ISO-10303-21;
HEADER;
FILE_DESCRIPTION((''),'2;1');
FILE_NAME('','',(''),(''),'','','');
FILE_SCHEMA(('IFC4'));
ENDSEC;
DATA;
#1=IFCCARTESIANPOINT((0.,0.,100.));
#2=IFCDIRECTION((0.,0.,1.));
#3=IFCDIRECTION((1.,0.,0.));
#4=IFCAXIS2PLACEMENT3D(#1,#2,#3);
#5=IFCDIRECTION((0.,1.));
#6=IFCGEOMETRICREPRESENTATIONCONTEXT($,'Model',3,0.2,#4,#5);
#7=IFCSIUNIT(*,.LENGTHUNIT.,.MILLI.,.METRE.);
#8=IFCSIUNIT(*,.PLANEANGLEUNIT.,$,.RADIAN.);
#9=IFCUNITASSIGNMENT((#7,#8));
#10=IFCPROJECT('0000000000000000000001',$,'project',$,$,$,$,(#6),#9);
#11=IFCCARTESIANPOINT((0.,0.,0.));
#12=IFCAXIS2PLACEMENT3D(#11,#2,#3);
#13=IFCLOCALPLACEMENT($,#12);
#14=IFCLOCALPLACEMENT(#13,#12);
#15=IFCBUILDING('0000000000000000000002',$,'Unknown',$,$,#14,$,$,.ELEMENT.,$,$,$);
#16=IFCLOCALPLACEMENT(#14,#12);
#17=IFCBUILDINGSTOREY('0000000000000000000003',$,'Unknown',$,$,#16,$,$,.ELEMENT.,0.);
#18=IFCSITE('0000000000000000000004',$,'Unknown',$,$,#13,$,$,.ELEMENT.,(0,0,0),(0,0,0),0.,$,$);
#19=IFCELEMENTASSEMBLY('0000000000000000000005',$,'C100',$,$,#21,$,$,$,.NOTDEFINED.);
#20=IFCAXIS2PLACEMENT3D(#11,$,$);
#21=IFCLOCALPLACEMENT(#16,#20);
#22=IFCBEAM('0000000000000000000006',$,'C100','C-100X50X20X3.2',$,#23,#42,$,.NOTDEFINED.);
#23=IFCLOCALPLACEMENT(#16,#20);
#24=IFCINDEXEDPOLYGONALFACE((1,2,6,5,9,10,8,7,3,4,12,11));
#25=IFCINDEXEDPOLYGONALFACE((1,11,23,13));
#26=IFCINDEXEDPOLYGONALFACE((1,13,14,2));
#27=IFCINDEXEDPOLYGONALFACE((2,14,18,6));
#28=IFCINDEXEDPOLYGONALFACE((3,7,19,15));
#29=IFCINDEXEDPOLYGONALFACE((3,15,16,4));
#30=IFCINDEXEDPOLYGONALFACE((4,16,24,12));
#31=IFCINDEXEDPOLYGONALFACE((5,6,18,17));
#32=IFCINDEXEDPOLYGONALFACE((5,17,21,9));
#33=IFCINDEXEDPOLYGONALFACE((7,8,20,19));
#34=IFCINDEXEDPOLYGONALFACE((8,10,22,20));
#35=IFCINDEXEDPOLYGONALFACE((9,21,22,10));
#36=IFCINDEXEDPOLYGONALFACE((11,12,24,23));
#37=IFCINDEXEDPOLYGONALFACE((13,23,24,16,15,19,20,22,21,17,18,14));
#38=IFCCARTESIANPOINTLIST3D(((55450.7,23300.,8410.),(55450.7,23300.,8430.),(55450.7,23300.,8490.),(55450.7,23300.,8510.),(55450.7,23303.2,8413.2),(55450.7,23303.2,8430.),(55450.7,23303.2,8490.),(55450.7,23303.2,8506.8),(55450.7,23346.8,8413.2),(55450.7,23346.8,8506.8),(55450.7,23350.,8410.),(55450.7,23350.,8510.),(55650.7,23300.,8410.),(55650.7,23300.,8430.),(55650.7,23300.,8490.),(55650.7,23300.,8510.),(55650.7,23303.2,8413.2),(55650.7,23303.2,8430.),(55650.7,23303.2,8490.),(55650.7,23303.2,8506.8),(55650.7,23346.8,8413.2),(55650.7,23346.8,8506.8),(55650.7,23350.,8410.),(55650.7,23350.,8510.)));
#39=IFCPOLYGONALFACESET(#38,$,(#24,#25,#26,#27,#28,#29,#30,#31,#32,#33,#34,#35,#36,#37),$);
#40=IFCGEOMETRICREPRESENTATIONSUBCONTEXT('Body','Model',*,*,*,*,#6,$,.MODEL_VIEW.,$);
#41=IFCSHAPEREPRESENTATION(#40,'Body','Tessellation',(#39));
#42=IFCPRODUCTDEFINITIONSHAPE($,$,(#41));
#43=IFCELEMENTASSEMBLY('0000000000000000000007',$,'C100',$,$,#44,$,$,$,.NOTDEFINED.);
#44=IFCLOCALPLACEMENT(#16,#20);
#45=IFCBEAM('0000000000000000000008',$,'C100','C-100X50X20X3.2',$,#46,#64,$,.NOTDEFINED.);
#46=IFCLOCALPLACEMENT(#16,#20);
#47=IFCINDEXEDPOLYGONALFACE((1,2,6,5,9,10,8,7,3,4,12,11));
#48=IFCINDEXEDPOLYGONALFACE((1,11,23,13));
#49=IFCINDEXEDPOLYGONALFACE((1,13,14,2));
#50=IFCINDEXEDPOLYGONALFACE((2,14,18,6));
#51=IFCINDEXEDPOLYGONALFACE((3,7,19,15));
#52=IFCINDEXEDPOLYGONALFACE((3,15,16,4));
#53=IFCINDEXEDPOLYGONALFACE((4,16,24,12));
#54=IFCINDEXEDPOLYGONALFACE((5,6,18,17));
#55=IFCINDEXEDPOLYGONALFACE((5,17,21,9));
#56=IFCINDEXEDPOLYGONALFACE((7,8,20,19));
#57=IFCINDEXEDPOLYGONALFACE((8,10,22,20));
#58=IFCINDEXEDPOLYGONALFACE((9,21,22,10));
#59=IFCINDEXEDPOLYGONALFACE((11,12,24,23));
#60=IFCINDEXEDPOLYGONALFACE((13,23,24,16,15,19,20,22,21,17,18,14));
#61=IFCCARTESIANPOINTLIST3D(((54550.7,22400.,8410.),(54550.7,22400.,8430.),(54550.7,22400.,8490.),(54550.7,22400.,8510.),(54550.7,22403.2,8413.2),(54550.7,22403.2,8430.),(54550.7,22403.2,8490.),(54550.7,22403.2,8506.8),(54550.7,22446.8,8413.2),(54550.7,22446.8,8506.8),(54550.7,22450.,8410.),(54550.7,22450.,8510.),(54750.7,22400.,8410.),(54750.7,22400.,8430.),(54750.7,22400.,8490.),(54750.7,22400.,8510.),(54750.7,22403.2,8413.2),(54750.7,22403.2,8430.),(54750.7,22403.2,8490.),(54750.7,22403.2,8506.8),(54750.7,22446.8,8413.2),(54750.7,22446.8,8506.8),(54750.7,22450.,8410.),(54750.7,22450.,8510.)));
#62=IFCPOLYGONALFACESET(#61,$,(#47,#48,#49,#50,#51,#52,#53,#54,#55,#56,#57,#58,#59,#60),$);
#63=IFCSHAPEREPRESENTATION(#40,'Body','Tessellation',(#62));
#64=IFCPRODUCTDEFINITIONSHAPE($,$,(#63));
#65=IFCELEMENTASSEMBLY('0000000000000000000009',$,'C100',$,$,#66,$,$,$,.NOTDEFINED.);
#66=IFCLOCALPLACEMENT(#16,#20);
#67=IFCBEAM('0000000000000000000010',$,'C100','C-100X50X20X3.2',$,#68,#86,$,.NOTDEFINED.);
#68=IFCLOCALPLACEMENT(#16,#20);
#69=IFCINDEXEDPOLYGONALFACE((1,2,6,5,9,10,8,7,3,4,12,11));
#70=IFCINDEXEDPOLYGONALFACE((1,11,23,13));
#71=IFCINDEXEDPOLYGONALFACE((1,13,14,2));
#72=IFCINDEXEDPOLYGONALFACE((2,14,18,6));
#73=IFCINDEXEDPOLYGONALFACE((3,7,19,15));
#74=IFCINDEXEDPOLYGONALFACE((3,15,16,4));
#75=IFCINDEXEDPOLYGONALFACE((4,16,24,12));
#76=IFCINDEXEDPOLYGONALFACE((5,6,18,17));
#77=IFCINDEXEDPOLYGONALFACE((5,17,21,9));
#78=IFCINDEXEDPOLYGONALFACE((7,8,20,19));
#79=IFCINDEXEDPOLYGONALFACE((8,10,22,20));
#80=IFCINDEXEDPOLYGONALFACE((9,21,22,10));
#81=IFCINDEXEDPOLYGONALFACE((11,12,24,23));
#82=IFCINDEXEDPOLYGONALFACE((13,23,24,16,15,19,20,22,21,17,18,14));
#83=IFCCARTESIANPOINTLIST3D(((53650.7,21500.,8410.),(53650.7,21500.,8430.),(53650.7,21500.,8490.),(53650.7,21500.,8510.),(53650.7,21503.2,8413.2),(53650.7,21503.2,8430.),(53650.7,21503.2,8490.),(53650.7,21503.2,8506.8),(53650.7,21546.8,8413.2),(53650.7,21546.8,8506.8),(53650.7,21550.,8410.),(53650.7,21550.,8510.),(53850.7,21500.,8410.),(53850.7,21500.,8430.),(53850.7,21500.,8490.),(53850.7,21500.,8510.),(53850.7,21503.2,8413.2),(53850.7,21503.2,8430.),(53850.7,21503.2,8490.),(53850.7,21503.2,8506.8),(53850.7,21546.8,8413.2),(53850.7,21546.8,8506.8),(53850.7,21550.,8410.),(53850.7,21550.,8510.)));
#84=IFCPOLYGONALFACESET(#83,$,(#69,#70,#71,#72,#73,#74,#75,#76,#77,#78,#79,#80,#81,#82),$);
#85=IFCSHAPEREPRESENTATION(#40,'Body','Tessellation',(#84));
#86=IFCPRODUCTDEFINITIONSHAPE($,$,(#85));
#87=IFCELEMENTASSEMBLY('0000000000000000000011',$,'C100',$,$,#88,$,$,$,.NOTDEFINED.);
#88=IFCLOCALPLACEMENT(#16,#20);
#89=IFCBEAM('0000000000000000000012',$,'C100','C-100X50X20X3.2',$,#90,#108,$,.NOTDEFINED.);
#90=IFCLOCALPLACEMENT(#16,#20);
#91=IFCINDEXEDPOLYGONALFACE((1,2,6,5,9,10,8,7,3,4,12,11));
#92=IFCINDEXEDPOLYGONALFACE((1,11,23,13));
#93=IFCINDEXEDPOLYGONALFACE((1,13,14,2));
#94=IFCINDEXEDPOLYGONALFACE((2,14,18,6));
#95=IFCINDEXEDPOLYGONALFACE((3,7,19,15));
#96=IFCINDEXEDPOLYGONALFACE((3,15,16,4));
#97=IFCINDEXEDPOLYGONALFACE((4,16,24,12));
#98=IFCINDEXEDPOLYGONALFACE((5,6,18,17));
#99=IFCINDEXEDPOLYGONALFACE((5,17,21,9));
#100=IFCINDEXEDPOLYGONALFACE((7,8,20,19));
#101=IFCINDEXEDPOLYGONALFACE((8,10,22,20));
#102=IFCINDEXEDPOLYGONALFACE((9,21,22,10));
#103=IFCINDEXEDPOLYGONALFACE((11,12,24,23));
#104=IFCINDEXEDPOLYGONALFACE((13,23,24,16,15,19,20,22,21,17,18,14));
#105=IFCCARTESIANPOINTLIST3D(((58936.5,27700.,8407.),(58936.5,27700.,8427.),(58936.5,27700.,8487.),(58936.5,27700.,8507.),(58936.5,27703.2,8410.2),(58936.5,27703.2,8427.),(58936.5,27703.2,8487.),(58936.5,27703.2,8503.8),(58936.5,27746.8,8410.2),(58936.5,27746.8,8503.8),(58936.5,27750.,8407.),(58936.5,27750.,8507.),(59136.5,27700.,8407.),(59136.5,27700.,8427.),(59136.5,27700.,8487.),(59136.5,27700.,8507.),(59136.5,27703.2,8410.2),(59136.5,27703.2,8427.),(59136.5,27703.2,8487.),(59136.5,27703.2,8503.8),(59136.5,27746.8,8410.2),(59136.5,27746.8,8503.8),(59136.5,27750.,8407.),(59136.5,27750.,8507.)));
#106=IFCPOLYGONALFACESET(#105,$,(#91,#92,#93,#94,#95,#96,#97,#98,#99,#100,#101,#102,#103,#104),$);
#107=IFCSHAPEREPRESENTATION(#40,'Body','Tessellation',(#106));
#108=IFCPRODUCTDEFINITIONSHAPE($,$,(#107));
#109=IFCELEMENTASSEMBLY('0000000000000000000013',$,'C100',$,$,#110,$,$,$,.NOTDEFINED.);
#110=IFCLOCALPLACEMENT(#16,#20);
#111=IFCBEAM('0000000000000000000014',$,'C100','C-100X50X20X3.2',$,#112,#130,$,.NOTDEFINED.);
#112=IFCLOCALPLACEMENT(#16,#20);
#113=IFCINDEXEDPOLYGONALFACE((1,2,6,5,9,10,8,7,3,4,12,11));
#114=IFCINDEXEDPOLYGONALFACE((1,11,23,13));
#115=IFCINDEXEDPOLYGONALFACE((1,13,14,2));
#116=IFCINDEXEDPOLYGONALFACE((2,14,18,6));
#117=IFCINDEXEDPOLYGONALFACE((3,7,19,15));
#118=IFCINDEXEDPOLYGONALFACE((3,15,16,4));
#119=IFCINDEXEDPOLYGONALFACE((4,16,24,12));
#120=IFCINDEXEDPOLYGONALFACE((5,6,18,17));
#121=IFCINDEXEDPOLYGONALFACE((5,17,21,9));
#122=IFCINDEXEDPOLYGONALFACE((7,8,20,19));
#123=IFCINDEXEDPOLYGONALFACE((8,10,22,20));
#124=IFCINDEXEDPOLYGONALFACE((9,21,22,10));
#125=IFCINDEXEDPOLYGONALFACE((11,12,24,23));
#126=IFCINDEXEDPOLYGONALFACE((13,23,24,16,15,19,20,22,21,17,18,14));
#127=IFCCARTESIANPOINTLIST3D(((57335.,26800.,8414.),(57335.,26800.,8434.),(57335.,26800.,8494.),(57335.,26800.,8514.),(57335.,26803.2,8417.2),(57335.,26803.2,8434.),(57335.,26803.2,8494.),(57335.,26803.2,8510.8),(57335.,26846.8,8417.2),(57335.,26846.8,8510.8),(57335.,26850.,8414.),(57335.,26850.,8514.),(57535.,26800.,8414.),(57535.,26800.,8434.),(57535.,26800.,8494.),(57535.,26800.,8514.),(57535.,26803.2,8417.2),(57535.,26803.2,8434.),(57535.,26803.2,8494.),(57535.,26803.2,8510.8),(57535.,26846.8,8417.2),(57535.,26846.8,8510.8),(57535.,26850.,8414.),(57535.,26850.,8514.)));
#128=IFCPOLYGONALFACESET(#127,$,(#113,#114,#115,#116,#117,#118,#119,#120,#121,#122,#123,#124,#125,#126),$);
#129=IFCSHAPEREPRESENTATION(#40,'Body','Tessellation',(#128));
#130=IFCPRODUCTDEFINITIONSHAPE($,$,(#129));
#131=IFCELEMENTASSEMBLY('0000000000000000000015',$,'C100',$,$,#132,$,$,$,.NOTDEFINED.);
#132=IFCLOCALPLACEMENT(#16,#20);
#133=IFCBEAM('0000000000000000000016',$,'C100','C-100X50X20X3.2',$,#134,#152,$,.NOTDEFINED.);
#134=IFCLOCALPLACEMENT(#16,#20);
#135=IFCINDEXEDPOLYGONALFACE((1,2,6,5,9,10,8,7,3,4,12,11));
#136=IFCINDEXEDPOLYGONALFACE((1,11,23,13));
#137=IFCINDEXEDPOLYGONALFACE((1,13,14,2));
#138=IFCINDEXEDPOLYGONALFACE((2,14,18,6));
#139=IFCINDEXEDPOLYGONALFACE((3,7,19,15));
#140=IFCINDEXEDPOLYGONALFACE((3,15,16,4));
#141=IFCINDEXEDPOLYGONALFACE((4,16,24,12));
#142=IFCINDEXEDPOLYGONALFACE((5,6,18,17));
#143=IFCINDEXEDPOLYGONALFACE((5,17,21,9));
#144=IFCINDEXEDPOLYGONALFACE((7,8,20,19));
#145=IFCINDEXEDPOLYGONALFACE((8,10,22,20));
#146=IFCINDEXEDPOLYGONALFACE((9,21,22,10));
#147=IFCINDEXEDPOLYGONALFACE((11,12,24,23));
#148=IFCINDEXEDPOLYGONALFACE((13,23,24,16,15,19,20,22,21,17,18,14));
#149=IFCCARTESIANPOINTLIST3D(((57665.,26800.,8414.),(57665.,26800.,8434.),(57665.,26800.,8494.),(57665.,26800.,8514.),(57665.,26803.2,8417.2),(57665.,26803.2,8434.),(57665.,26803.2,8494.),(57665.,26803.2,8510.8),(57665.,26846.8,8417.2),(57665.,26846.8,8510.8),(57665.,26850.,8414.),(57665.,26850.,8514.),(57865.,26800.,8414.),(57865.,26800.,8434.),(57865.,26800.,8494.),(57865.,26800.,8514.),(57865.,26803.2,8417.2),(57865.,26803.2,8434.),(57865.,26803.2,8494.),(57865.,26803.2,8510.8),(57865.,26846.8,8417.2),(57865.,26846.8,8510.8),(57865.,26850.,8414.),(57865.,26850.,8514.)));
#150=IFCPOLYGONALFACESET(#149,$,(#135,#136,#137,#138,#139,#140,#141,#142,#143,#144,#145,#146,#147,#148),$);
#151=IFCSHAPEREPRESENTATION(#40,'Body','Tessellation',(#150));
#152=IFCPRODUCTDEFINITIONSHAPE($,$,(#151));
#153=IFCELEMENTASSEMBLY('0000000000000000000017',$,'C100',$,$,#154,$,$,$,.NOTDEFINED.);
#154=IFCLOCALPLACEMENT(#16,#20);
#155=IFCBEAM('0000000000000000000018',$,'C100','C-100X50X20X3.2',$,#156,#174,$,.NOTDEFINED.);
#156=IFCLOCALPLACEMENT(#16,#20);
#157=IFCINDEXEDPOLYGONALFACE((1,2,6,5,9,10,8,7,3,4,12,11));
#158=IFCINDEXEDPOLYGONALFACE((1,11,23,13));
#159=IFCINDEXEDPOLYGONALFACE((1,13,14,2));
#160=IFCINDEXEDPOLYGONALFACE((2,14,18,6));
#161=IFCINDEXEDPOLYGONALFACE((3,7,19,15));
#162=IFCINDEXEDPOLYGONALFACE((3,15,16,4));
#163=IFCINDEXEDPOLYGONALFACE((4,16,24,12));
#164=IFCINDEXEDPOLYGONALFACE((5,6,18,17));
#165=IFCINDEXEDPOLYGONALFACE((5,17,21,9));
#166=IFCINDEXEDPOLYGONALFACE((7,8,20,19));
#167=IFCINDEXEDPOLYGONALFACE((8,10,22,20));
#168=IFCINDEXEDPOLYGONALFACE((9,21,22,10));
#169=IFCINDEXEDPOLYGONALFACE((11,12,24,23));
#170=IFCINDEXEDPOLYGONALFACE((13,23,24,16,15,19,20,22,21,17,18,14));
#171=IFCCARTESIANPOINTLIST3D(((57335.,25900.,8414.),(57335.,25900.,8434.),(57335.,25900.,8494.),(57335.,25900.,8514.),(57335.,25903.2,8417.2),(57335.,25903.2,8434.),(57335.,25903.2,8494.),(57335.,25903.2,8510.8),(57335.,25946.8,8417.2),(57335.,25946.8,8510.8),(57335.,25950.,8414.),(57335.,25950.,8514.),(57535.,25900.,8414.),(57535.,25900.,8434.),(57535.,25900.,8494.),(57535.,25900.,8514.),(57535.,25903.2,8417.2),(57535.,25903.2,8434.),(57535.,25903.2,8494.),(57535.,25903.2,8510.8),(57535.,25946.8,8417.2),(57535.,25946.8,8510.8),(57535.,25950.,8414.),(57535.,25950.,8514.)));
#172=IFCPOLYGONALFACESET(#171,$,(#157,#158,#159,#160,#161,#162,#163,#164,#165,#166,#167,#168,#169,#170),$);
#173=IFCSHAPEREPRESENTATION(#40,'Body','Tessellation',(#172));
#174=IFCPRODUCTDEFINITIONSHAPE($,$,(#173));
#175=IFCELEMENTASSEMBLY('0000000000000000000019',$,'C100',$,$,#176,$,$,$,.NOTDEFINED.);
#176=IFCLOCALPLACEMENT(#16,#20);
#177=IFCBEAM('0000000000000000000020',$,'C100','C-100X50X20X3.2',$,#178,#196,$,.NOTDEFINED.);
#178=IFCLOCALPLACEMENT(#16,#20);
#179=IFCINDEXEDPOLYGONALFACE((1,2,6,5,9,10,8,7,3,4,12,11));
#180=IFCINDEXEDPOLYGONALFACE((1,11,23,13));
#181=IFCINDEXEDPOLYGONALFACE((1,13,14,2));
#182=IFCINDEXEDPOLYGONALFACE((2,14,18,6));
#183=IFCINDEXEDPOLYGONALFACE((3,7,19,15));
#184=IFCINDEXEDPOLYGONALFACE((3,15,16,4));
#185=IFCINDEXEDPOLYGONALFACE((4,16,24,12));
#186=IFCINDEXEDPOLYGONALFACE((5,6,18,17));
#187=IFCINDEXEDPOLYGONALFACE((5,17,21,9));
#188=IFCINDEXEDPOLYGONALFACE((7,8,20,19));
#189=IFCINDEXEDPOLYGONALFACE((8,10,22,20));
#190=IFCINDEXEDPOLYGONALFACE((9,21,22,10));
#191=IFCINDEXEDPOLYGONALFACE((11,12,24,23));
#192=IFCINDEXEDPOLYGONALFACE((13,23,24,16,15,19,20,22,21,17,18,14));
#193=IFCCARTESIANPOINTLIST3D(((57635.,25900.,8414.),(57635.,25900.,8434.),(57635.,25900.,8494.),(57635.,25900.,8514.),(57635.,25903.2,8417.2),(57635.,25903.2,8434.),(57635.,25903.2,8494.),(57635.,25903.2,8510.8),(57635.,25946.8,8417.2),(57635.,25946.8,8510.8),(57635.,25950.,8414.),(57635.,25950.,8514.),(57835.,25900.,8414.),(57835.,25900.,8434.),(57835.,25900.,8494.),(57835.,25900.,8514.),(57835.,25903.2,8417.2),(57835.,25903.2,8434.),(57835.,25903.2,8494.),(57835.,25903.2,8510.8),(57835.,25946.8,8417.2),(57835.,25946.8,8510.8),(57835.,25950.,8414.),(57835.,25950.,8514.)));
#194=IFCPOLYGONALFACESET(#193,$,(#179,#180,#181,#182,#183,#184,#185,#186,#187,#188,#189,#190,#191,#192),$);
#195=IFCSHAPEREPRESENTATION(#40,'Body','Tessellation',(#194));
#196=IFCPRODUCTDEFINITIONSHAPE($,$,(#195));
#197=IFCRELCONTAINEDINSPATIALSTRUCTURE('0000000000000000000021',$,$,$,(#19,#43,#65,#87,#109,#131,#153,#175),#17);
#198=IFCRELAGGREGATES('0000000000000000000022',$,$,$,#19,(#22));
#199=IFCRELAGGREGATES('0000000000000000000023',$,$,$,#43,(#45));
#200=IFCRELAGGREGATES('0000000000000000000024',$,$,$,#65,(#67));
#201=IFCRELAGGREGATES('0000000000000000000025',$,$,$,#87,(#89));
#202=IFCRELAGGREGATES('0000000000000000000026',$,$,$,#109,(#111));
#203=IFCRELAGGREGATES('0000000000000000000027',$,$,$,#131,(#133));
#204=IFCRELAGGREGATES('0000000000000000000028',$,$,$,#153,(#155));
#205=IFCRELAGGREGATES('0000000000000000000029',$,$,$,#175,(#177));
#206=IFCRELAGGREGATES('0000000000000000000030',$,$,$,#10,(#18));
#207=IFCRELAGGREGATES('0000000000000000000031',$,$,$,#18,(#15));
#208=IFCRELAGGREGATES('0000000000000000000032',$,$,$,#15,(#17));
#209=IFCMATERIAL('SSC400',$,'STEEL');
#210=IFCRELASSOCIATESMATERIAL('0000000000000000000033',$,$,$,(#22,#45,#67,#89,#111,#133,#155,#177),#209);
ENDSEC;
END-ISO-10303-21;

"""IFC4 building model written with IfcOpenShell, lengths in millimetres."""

from ifc_helpers import new_model, si_unit, direction, frame, origin_with_axes, place, context, subcontext, project, spatial, line, indexed_curve, outline, extrude, material, element, aggregate, save


model = new_model("IFC4")

# Units and contexts
model_context = context("Model", 3, precision=0.2, world=frame((0.0, 0.0, 100.0), z_axis=(0.0, 0.0, 1.0), x_axis=(1.0, 0.0, 0.0)), true_north=direction((0.0, 1.0)))
body_context = subcontext(model_context, "Body", "Model", "MODEL_VIEW")
ifc_project = project(units=[si_unit("LENGTHUNIT", "METRE", prefix="MILLI"), si_unit("PLANEANGLEUNIT", "RADIAN")], contexts=[model_context])

# Site, building, storey
site_placement = place(None, origin_with_axes())
site = spatial("IfcSite", under=ifc_project, at=site_placement, Name="Unknown", CompositionType="ELEMENT", RefLatitude=(0, 0, 0), RefLongitude=(0, 0, 0), RefElevation=0.0)
building_placement = place(site_placement, origin_with_axes())
building = spatial("IfcBuilding", under=site, at=building_placement, Name="Unknown", CompositionType="ELEMENT")
storey_placement = place(building_placement, origin_with_axes())
storey = spatial("IfcBuildingStorey", under=building, at=storey_placement, Name="Unknown", CompositionType="ELEMENT", Elevation=0.0)

# Element assemblies, beams
ifc_material_1 = material(Name="SSC400", Category="STEEL")
assembly_1_placement = place(storey_placement, frame((55450.7, 23325.0, 8460.0), z_axis=(0.0, -1.0, 0.0), x_axis=(1.0, 0.0, 0.0)))
assembly_1 = element("IfcElementAssembly", 1, at=assembly_1_placement, inside=storey, Name="C100", PredefinedType="NOTDEFINED")
beam_1_placement = place(assembly_1_placement, origin_with_axes())
beam_1 = element("IfcBeam", 2, at=beam_1_placement, material=ifc_material_1, Name="C100", Description="C-100X50X20X3.2", PredefinedType="NOTDEFINED", context=body_context, shape_type="SolidModel", body=[
    extrude(outline(indexed_curve([(25.0, -50.0), (25.0, -30.0), (21.8, -30.0), (21.8, -46.8), (-21.8, -46.8), (-21.8, 46.8), (21.8, 46.8), (21.8, 30.0), (25.0, 30.0), (25.0, 50.0), (-25.0, 50.0), (-25.0, -50.0)], segments=[line(1, 2, 3, 4, 5, 6, 7, 8, 9, 10, 11, 12, 1)])), frame((0.0, 0.0, 0.0), z_axis=(-1.0, 0.0, 0.0), x_axis=(0.0, 0.0, 1.0)), (0.0, 0.0, -1.0), 200.0),
])
aggregate(assembly_1, [beam_1])
assembly_2_placement = place(storey_placement, frame((54550.7, 22425.0, 8460.0), z_axis=(0.0, -1.0, 0.0), x_axis=(1.0, 0.0, 0.0)))
assembly_2 = element("IfcElementAssembly", 3, at=assembly_2_placement, inside=storey, Name="C100", PredefinedType="NOTDEFINED")
beam_2_placement = place(assembly_2_placement, origin_with_axes())
beam_2 = element("IfcBeam", 4, at=beam_2_placement, material=ifc_material_1, Name="C100", Description="C-100X50X20X3.2", PredefinedType="NOTDEFINED", context=body_context, shape_type="SolidModel", body=[
    extrude(outline(indexed_curve([(25.0, -50.0), (25.0, -30.0), (21.8, -30.0), (21.8, -46.8), (-21.8, -46.8), (-21.8, 46.8), (21.8, 46.8), (21.8, 30.0), (25.0, 30.0), (25.0, 50.0), (-25.0, 50.0), (-25.0, -50.0)], segments=[line(1, 2, 3, 4, 5, 6, 7, 8, 9, 10, 11, 12, 1)])), frame((0.0, 0.0, 0.0), z_axis=(-1.0, 0.0, 0.0), x_axis=(0.0, 0.0, 1.0)), (0.0, 0.0, -1.0), 200.0),
])
aggregate(assembly_2, [beam_2])
assembly_3_placement = place(storey_placement, frame((53650.7, 21525.0, 8460.0), z_axis=(0.0, -1.0, 0.0), x_axis=(1.0, 0.0, 0.0)))
assembly_3 = element("IfcElementAssembly", 5, at=assembly_3_placement, inside=storey, Name="C100", PredefinedType="NOTDEFINED")
beam_3_placement = place(assembly_3_placement, origin_with_axes())
beam_3 = element("IfcBeam", 6, at=beam_3_placement, material=ifc_material_1, Name="C100", Description="C-100X50X20X3.2", PredefinedType="NOTDEFINED", context=body_context, shape_type="SolidModel", body=[
    extrude(outline(indexed_curve([(25.0, -50.0), (25.0, -30.0), (21.8, -30.0), (21.8, -46.8), (-21.8, -46.8), (-21.8, 46.8), (21.8, 46.8), (21.8, 30.0), (25.0, 30.0), (25.0, 50.0), (-25.0, 50.0), (-25.0, -50.0)], segments=[line(1, 2, 3, 4, 5, 6, 7, 8, 9, 10, 11, 12, 1)])), frame((0.0, 0.0, 0.0), z_axis=(-1.0, 0.0, 0.0), x_axis=(0.0, 0.0, 1.0)), (0.0, 0.0, -1.0), 200.0),
])
aggregate(assembly_3, [beam_3])
assembly_4_placement = place(storey_placement, frame((58936.5, 27725.0, 8457.0), z_axis=(0.0, -1.0, 0.0), x_axis=(1.0, 0.0, 0.0)))
assembly_4 = element("IfcElementAssembly", 7, at=assembly_4_placement, inside=storey, Name="C100", PredefinedType="NOTDEFINED")
beam_4_placement = place(assembly_4_placement, origin_with_axes())
beam_4 = element("IfcBeam", 8, at=beam_4_placement, material=ifc_material_1, Name="C100", Description="C-100X50X20X3.2", PredefinedType="NOTDEFINED", context=body_context, shape_type="SolidModel", body=[
    extrude(outline(indexed_curve([(25.0, -50.0), (25.0, -30.0), (21.8, -30.0), (21.8, -46.8), (-21.8, -46.8), (-21.8, 46.8), (21.8, 46.8), (21.8, 30.0), (25.0, 30.0), (25.0, 50.0), (-25.0, 50.0), (-25.0, -50.0)], segments=[line(1, 2, 3, 4, 5, 6, 7, 8, 9, 10, 11, 12, 1)])), frame((0.0, 0.0, 0.0), z_axis=(-1.0, 0.0, 0.0), x_axis=(0.0, 0.0, 1.0)), (0.0, 0.0, -1.0), 200.0),
])
aggregate(assembly_4, [beam_4])
assembly_5_placement = place(storey_placement, frame((57335.0, 26825.0, 8464.0), z_axis=(0.0, -1.0, 0.0), x_axis=(1.0, 0.0, 0.0)))
assembly_5 = element("IfcElementAssembly", 9, at=assembly_5_placement, inside=storey, Name="C100", PredefinedType="NOTDEFINED")
beam_5_placement = place(assembly_5_placement, origin_with_axes())
beam_5 = element("IfcBeam", 10, at=beam_5_placement, material=ifc_material_1, Name="C100", Description="C-100X50X20X3.2", PredefinedType="NOTDEFINED", context=body_context, shape_type="SolidModel", body=[
    extrude(outline(indexed_curve([(25.0, -50.0), (25.0, -30.0), (21.8, -30.0), (21.8, -46.8), (-21.8, -46.8), (-21.8, 46.8), (21.8, 46.8), (21.8, 30.0), (25.0, 30.0), (25.0, 50.0), (-25.0, 50.0), (-25.0, -50.0)], segments=[line(1, 2, 3, 4, 5, 6, 7, 8, 9, 10, 11, 12, 1)])), frame((0.0, 0.0, 0.0), z_axis=(-1.0, 0.0, 0.0), x_axis=(0.0, 0.0, 1.0)), (0.0, 0.0, -1.0), 200.0),
])
aggregate(assembly_5, [beam_5])
assembly_6_placement = place(storey_placement, frame((57665.0, 26825.0, 8464.0), z_axis=(0.0, -1.0, 0.0), x_axis=(1.0, 0.0, 0.0)))
assembly_6 = element("IfcElementAssembly", 11, at=assembly_6_placement, inside=storey, Name="C100", PredefinedType="NOTDEFINED")
beam_6_placement = place(assembly_6_placement, origin_with_axes())
beam_6 = element("IfcBeam", 12, at=beam_6_placement, material=ifc_material_1, Name="C100", Description="C-100X50X20X3.2", PredefinedType="NOTDEFINED", context=body_context, shape_type="SolidModel", body=[
    extrude(outline(indexed_curve([(25.0, -50.0), (25.0, -30.0), (21.8, -30.0), (21.8, -46.8), (-21.8, -46.8), (-21.8, 46.8), (21.8, 46.8), (21.8, 30.0), (25.0, 30.0), (25.0, 50.0), (-25.0, 50.0), (-25.0, -50.0)], segments=[line(1, 2, 3, 4, 5, 6, 7, 8, 9, 10, 11, 12, 1)])), frame((0.0, 0.0, 0.0), z_axis=(-1.0, 0.0, 0.0), x_axis=(0.0, 0.0, 1.0)), (0.0, 0.0, -1.0), 200.0),
])
aggregate(assembly_6, [beam_6])
assembly_7_placement = place(storey_placement, frame((57335.0, 25925.0, 8464.0), z_axis=(0.0, -1.0, 0.0), x_axis=(1.0, 0.0, 0.0)))
assembly_7 = element("IfcElementAssembly", 13, at=assembly_7_placement, inside=storey, Name="C100", PredefinedType="NOTDEFINED")
beam_7_placement = place(assembly_7_placement, origin_with_axes())
beam_7 = element("IfcBeam", 14, at=beam_7_placement, material=ifc_material_1, Name="C100", Description="C-100X50X20X3.2", PredefinedType="NOTDEFINED", context=body_context, shape_type="SolidModel", body=[
    extrude(outline(indexed_curve([(25.0, -50.0), (25.0, -30.0), (21.8, -30.0), (21.8, -46.8), (-21.8, -46.8), (-21.8, 46.8), (21.8, 46.8), (21.8, 30.0), (25.0, 30.0), (25.0, 50.0), (-25.0, 50.0), (-25.0, -50.0)], segments=[line(1, 2, 3, 4, 5, 6, 7, 8, 9, 10, 11, 12, 1)])), frame((0.0, 0.0, 0.0), z_axis=(-1.0, 0.0, 0.0), x_axis=(0.0, 0.0, 1.0)), (0.0, 0.0, -1.0), 200.0),
])
aggregate(assembly_7, [beam_7])
assembly_8_placement = place(storey_placement, frame((57635.0, 25925.0, 8464.0), z_axis=(0.0, -1.0, 0.0), x_axis=(1.0, 0.0, 0.0)))
assembly_8 = element("IfcElementAssembly", 15, at=assembly_8_placement, inside=storey, Name="C100", PredefinedType="NOTDEFINED")
beam_8_placement = place(assembly_8_placement, origin_with_axes())
beam_8 = element("IfcBeam", 16, at=beam_8_placement, material=ifc_material_1, Name="C100", Description="C-100X50X20X3.2", PredefinedType="NOTDEFINED", context=body_context, shape_type="SolidModel", body=[
    extrude(outline(indexed_curve([(25.0, -50.0), (25.0, -30.0), (21.8, -30.0), (21.8, -46.8), (-21.8, -46.8), (-21.8, 46.8), (21.8, 46.8), (21.8, 30.0), (25.0, 30.0), (25.0, 50.0), (-25.0, 50.0), (-25.0, -50.0)], segments=[line(1, 2, 3, 4, 5, 6, 7, 8, 9, 10, 11, 12, 1)])), frame((0.0, 0.0, 0.0), z_axis=(-1.0, 0.0, 0.0), x_axis=(0.0, 0.0, 1.0)), (0.0, 0.0, -1.0), 200.0),
])
aggregate(assembly_8, [beam_8])

save(model, "model.ifc")
